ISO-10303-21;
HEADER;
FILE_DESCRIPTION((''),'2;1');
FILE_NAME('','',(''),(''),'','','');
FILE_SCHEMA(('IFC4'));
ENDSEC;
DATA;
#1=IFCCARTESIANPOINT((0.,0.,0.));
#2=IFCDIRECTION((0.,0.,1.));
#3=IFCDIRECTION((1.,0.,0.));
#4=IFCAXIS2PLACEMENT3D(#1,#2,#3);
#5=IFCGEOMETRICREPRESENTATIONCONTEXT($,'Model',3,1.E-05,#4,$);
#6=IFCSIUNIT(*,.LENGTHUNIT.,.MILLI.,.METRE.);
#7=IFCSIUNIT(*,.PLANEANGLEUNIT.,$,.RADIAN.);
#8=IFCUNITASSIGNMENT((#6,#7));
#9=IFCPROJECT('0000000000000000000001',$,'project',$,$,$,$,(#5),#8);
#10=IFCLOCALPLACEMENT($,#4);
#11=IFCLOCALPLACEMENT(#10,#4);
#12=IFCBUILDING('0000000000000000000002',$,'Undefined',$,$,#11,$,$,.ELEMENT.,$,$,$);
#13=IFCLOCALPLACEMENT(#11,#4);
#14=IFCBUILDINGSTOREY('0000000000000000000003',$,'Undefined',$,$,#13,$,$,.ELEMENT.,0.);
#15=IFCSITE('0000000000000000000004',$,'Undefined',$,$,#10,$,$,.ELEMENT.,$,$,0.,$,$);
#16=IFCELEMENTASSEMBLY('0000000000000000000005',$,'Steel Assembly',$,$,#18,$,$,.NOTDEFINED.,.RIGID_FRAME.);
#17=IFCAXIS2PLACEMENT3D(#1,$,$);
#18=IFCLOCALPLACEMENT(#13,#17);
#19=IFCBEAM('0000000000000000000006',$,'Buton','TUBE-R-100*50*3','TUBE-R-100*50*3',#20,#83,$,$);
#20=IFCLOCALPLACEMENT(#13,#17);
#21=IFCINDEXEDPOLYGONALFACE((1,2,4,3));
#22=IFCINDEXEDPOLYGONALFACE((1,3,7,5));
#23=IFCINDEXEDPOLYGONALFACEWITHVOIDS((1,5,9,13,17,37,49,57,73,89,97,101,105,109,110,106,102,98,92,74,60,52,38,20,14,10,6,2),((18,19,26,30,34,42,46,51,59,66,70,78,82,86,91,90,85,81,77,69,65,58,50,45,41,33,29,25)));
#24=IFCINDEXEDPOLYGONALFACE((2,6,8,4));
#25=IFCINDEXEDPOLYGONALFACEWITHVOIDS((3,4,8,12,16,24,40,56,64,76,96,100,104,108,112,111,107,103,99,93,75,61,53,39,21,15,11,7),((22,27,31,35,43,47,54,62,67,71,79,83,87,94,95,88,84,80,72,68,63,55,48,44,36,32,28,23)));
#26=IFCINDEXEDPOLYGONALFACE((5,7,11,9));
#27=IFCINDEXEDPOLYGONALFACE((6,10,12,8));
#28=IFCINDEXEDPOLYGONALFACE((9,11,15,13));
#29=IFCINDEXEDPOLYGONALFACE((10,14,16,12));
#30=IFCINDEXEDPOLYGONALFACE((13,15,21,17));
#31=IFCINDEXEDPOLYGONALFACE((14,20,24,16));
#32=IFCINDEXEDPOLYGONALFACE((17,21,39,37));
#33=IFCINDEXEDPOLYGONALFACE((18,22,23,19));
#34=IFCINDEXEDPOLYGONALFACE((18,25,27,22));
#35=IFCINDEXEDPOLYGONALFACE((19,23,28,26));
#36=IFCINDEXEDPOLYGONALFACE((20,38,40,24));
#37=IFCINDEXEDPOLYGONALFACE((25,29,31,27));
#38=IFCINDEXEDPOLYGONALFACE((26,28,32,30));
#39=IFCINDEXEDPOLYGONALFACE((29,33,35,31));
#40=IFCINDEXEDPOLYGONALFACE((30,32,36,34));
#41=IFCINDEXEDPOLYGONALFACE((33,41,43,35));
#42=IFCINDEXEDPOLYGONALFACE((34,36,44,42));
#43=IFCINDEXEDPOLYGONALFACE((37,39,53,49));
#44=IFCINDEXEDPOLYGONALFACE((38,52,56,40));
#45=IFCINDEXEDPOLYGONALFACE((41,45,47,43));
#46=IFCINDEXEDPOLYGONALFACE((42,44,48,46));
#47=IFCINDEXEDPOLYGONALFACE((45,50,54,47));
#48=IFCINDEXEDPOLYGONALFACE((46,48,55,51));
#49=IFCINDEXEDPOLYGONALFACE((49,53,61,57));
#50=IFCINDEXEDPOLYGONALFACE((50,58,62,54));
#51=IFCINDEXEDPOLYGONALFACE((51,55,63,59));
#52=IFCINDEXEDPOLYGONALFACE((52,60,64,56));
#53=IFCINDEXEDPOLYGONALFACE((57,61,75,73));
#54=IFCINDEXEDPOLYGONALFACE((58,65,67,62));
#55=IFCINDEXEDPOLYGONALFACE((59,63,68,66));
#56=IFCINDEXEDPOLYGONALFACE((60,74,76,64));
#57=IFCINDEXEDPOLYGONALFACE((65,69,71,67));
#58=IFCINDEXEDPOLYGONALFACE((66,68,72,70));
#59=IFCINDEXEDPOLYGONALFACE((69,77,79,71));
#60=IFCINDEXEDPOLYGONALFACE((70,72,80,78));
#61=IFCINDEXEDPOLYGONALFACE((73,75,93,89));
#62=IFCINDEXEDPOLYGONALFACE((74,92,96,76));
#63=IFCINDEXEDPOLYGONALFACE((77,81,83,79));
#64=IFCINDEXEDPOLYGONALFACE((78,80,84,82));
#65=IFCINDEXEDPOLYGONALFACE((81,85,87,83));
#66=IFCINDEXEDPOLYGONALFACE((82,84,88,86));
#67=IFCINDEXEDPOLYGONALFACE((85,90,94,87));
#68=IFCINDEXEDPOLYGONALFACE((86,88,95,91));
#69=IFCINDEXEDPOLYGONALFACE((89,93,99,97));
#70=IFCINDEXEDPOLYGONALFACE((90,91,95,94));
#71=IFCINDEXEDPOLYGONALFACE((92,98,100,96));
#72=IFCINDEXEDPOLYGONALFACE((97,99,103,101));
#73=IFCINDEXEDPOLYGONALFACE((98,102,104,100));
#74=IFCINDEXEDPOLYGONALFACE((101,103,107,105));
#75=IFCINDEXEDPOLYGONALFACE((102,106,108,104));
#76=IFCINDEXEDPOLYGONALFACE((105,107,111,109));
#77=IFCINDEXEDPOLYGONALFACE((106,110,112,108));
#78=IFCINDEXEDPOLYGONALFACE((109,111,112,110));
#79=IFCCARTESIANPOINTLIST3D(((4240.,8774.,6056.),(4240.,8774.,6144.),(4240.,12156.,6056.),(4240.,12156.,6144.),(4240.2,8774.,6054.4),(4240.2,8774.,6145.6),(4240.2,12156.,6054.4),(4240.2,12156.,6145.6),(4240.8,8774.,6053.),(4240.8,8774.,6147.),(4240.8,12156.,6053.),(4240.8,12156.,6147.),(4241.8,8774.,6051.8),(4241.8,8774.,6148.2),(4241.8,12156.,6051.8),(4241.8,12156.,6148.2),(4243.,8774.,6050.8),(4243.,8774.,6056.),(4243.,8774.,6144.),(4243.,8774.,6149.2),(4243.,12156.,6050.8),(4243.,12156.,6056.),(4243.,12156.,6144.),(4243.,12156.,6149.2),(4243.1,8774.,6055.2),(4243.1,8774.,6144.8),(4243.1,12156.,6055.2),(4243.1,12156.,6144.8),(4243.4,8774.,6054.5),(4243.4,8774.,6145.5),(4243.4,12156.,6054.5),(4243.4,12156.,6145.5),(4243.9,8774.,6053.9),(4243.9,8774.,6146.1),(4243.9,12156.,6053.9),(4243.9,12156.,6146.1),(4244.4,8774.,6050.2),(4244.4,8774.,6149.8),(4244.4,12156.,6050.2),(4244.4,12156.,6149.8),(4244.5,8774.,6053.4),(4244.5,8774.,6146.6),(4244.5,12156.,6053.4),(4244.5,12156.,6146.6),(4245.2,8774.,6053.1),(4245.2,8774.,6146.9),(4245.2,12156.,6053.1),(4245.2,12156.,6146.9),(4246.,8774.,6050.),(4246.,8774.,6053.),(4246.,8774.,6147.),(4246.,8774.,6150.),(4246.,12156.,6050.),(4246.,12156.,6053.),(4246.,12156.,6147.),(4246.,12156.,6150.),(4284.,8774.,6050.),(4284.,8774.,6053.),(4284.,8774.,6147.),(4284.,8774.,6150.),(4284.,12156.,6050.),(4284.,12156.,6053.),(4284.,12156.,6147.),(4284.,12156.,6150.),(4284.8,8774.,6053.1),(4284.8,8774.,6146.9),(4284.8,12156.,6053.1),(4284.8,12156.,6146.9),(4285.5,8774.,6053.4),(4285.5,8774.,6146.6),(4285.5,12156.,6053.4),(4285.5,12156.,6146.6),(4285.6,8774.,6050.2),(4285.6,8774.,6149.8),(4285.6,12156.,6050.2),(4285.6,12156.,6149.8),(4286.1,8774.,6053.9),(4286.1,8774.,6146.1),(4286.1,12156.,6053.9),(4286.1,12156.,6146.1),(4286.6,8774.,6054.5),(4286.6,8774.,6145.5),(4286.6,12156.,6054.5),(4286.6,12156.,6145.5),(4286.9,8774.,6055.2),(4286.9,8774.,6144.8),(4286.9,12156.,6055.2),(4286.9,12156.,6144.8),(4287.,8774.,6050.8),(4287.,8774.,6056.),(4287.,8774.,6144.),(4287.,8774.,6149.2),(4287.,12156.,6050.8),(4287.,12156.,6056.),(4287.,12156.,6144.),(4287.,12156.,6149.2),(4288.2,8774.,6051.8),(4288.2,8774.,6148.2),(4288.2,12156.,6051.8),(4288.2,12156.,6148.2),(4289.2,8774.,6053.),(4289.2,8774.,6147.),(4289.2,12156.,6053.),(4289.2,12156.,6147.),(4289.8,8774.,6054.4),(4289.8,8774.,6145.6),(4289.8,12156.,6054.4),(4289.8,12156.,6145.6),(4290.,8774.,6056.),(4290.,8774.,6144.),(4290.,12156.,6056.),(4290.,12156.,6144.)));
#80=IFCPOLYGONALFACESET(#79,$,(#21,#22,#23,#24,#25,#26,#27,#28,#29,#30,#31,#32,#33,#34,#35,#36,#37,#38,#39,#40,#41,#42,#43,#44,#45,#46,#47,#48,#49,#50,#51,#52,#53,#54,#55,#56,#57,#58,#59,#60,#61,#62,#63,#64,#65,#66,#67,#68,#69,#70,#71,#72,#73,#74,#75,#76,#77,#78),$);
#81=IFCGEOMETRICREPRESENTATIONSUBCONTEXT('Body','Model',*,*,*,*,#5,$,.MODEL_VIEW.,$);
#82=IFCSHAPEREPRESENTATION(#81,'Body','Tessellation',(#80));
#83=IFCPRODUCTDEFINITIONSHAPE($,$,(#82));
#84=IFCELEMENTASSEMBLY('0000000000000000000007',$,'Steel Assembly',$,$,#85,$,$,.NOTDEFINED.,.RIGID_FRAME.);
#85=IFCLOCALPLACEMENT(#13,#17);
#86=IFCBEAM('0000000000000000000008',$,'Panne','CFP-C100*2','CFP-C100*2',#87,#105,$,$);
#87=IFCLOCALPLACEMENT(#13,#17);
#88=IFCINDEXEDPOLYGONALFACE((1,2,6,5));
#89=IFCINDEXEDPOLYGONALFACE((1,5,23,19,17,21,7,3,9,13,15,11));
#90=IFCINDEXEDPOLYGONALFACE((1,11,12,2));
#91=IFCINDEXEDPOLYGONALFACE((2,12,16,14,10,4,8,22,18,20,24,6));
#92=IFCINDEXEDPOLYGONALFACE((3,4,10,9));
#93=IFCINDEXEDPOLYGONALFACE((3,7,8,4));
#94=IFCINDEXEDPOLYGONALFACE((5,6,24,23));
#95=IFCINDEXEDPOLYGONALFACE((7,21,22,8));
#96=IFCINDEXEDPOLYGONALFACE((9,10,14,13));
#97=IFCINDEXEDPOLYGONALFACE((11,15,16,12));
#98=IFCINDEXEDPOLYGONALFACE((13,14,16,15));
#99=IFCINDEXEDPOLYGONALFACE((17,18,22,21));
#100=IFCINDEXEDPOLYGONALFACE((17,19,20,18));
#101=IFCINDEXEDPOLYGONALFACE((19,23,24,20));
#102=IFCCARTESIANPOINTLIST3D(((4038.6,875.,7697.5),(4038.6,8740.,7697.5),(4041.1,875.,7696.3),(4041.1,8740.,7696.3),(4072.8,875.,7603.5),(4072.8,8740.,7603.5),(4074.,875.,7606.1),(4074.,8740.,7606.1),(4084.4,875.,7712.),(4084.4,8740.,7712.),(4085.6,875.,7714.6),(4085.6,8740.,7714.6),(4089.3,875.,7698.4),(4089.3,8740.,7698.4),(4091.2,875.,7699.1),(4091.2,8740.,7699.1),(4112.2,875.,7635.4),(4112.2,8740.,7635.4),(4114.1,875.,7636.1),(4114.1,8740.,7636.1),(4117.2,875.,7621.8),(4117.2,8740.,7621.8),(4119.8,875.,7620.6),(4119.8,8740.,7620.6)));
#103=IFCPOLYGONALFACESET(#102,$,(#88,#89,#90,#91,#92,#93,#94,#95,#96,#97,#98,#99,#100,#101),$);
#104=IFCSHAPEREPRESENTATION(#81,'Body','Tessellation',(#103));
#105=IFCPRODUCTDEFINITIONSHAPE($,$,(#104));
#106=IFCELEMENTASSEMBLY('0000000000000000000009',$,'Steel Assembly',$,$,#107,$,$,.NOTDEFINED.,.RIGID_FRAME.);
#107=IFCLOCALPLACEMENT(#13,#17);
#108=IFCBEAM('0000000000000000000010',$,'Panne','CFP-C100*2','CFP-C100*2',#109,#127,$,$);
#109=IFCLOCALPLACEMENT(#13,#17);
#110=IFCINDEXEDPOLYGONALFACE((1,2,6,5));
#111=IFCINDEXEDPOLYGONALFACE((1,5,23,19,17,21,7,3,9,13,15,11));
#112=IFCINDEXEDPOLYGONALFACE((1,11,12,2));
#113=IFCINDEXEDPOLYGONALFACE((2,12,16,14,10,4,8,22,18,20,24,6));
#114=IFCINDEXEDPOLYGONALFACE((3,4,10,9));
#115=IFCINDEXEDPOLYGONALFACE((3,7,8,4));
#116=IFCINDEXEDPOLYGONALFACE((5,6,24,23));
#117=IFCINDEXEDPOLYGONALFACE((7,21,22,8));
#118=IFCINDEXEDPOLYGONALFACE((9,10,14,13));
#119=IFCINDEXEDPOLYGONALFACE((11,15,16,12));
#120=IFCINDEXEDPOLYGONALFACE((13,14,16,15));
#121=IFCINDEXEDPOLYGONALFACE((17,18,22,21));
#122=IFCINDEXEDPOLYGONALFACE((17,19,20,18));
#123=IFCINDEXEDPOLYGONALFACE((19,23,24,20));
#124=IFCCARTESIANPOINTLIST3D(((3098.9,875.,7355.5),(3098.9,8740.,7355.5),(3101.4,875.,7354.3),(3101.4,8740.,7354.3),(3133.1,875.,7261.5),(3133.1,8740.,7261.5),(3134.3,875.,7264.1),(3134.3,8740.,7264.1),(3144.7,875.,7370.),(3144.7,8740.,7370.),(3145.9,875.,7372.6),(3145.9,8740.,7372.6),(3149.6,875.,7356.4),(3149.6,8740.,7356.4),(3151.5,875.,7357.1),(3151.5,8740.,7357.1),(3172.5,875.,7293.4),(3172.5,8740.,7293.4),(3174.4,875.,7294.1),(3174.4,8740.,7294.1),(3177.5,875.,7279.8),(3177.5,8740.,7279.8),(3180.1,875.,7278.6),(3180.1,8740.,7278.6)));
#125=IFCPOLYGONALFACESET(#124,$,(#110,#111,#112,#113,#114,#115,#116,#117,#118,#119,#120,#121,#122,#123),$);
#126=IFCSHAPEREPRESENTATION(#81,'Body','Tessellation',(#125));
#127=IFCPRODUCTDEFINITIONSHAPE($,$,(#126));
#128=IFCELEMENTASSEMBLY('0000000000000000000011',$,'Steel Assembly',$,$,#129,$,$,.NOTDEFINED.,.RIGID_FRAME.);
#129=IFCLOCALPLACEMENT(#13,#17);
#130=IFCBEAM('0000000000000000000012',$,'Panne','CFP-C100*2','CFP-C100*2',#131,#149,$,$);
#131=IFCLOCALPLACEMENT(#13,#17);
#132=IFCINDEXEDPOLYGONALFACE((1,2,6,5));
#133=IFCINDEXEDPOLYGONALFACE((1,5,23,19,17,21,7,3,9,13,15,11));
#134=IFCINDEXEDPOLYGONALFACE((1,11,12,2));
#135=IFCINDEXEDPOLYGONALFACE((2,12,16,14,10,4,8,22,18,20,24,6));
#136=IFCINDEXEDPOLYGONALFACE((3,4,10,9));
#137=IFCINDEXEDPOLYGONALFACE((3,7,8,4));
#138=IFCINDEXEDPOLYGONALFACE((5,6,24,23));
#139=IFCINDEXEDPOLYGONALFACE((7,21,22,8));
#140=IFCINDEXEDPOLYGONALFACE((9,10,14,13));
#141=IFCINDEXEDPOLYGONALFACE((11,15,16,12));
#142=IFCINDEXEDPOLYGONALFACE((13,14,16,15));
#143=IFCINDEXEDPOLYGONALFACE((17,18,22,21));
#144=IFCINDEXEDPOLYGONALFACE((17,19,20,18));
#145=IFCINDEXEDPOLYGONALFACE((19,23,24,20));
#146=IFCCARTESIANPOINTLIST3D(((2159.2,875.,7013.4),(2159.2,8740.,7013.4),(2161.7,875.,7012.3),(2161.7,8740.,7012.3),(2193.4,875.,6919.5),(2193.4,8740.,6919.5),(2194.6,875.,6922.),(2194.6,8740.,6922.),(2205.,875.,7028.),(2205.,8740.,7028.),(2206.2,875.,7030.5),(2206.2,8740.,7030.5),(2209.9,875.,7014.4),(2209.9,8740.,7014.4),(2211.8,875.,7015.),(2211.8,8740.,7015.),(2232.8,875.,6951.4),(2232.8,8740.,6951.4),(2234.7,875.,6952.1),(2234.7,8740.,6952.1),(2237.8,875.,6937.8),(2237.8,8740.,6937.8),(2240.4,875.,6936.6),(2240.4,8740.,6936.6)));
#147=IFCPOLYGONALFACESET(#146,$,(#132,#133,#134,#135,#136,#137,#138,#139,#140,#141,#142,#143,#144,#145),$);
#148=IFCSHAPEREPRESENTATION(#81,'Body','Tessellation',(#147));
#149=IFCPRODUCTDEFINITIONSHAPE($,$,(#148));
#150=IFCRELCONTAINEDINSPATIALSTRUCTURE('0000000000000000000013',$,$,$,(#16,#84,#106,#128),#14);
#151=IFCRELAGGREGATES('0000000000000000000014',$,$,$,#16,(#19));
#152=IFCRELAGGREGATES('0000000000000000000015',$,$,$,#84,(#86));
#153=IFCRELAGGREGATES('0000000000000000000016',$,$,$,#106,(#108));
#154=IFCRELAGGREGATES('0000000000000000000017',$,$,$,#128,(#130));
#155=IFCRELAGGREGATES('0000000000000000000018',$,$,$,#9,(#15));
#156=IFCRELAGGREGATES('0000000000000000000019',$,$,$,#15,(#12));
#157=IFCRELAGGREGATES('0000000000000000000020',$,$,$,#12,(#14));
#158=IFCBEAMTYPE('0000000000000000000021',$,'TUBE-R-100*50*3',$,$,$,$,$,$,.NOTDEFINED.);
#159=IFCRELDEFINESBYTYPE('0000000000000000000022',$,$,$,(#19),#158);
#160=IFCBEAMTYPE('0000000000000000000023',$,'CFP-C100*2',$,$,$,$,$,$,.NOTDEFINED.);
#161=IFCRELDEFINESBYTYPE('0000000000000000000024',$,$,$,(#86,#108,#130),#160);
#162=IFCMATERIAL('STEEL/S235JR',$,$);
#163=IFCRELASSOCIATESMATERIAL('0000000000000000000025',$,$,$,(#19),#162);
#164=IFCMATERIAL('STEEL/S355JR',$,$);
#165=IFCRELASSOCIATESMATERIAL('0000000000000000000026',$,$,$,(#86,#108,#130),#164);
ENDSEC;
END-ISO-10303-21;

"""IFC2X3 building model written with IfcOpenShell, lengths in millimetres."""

from ifc_helpers import new_model, si_unit, frame, origin_with_axes, origin_2d_with_axis, place, context, subcontext, project, spatial, hollow_rectangle, c_section, extrude, material, type_object, element, aggregate, save


model = new_model("IFC2X3")

# Units and contexts
model_context = context("Model", 3, precision=1e-05, world=origin_with_axes())
body_context = subcontext(model_context, "Body", "Model", "MODEL_VIEW")
ifc_project = project(units=[si_unit("LENGTHUNIT", "METRE", prefix="MILLI"), si_unit("PLANEANGLEUNIT", "RADIAN")], contexts=[model_context])

# Site, building, storey
site_placement = place(None, origin_with_axes())
site = spatial("IfcSite", under=ifc_project, at=site_placement, Name="Undefined", CompositionType="ELEMENT", RefElevation=0.0)
building_placement = place(site_placement, origin_with_axes())
building = spatial("IfcBuilding", under=site, at=building_placement, Name="Undefined", CompositionType="ELEMENT")
storey_placement = place(building_placement, origin_with_axes())
storey = spatial("IfcBuildingStorey", under=building, at=storey_placement, Name="Undefined", CompositionType="ELEMENT", Elevation=0.0)

# Element assemblies, beams
assembly_1_placement = place(storey_placement, origin_with_axes())
assembly_1 = element("IfcElementAssembly", 1, at=assembly_1_placement, inside=storey, Name="Steel Assembly", AssemblyPlace="NOTDEFINED", PredefinedType="RIGID_FRAME")
ifc_material_1 = material(Name="STEEL/S235JR")
beam_type_1 = type_object("IfcBeamType", Name="TUBE-R-100*50*3", PredefinedType="NOTDEFINED")
beam_1_placement = place(assembly_1_placement, frame((4265.0, 8715.0, 6100.0), z_axis=(0.0, 0.0, 1.0), x_axis=(0.0, 1.0, 0.0)))
beam_1 = element("IfcBeam", 2, at=beam_1_placement, type_object=beam_type_1, material=ifc_material_1, Name="Buton", Description="TUBE-R-100*50*3", ObjectType="TUBE-R-100*50*3", context=body_context, shape_type="SweptSolid", body=[
    extrude(hollow_rectangle(XDim=50.0, YDim=100.0, WallThickness=3.0, InnerFilletRadius=3.0, OuterFilletRadius=6.0, at=origin_2d_with_axis()), frame((3441.0, 0.0, 0.0), z_axis=(-1.0, 0.0, 0.0), x_axis=(0.0, -1.0, 0.0)), (0.0, 0.0, 1.0), 3382.0),
])
aggregate(assembly_1, [beam_1])
assembly_2_placement = place(storey_placement, origin_with_axes())
assembly_2 = element("IfcElementAssembly", 3, at=assembly_2_placement, inside=storey, Name="Steel Assembly", AssemblyPlace="NOTDEFINED", PredefinedType="RIGID_FRAME")
ifc_material_2 = material(Name="STEEL/S355JR")
beam_type_2 = type_object("IfcBeamType", Name="CFP-C100*2", PredefinedType="NOTDEFINED")
beam_2_placement = place(assembly_2_placement, frame((4079.2, 8740.0, 7659.1), z_axis=(0.34202, 0.0, -0.939693), x_axis=(0.0, -1.0, 0.0)))
beam_2 = element("IfcBeam", 4, at=beam_2_placement, type_object=beam_type_2, material=ifc_material_2, Name="Panne", Description="CFP-C100*2", ObjectType="CFP-C100*2", context=body_context, shape_type="SweptSolid", body=[
    extrude(c_section(Depth=100.0, Width=50.0, WallThickness=2.0, Girth=16.5, at=origin_2d_with_axis()), frame((7865.0, 0.0, 0.0), z_axis=(-1.0, 0.0, 0.0), x_axis=(0.0, -1.0, 0.0)), (0.0, 0.0, 1.0), 7865.0),
])
aggregate(assembly_2, [beam_2])
assembly_3_placement = place(storey_placement, origin_with_axes())
assembly_3 = element("IfcElementAssembly", 5, at=assembly_3_placement, inside=storey, Name="Steel Assembly", AssemblyPlace="NOTDEFINED", PredefinedType="RIGID_FRAME")
beam_3_placement = place(assembly_3_placement, frame((3139.5, 8740.0, 7317.0), z_axis=(0.34202, 0.0, -0.939693), x_axis=(0.0, -1.0, 0.0)))
beam_3 = element("IfcBeam", 6, at=beam_3_placement, type_object=beam_type_2, material=ifc_material_2, Name="Panne", Description="CFP-C100*2", ObjectType="CFP-C100*2", context=body_context, shape_type="SweptSolid", body=[
    extrude(c_section(Depth=100.0, Width=50.0, WallThickness=2.0, Girth=16.5, at=origin_2d_with_axis()), frame((7865.0, 0.0, 0.0), z_axis=(-1.0, 0.0, 0.0), x_axis=(0.0, -1.0, 0.0)), (0.0, 0.0, 1.0), 7865.0),
])
aggregate(assembly_3, [beam_3])
assembly_4_placement = place(storey_placement, origin_with_axes())
assembly_4 = element("IfcElementAssembly", 7, at=assembly_4_placement, inside=storey, Name="Steel Assembly", AssemblyPlace="NOTDEFINED", PredefinedType="RIGID_FRAME")
beam_4_placement = place(assembly_4_placement, frame((2199.8, 8740.0, 6975.0), z_axis=(0.34202, 0.0, -0.939693), x_axis=(0.0, -1.0, 0.0)))
beam_4 = element("IfcBeam", 8, at=beam_4_placement, type_object=beam_type_2, material=ifc_material_2, Name="Panne", Description="CFP-C100*2", ObjectType="CFP-C100*2", context=body_context, shape_type="SweptSolid", body=[
    extrude(c_section(Depth=100.0, Width=50.0, WallThickness=2.0, Girth=16.5, at=origin_2d_with_axis()), frame((7865.0, 0.0, 0.0), z_axis=(-1.0, 0.0, 0.0), x_axis=(0.0, -1.0, 0.0)), (0.0, 0.0, 1.0), 7865.0),
])
aggregate(assembly_4, [beam_4])

save(model, "model.ifc")
